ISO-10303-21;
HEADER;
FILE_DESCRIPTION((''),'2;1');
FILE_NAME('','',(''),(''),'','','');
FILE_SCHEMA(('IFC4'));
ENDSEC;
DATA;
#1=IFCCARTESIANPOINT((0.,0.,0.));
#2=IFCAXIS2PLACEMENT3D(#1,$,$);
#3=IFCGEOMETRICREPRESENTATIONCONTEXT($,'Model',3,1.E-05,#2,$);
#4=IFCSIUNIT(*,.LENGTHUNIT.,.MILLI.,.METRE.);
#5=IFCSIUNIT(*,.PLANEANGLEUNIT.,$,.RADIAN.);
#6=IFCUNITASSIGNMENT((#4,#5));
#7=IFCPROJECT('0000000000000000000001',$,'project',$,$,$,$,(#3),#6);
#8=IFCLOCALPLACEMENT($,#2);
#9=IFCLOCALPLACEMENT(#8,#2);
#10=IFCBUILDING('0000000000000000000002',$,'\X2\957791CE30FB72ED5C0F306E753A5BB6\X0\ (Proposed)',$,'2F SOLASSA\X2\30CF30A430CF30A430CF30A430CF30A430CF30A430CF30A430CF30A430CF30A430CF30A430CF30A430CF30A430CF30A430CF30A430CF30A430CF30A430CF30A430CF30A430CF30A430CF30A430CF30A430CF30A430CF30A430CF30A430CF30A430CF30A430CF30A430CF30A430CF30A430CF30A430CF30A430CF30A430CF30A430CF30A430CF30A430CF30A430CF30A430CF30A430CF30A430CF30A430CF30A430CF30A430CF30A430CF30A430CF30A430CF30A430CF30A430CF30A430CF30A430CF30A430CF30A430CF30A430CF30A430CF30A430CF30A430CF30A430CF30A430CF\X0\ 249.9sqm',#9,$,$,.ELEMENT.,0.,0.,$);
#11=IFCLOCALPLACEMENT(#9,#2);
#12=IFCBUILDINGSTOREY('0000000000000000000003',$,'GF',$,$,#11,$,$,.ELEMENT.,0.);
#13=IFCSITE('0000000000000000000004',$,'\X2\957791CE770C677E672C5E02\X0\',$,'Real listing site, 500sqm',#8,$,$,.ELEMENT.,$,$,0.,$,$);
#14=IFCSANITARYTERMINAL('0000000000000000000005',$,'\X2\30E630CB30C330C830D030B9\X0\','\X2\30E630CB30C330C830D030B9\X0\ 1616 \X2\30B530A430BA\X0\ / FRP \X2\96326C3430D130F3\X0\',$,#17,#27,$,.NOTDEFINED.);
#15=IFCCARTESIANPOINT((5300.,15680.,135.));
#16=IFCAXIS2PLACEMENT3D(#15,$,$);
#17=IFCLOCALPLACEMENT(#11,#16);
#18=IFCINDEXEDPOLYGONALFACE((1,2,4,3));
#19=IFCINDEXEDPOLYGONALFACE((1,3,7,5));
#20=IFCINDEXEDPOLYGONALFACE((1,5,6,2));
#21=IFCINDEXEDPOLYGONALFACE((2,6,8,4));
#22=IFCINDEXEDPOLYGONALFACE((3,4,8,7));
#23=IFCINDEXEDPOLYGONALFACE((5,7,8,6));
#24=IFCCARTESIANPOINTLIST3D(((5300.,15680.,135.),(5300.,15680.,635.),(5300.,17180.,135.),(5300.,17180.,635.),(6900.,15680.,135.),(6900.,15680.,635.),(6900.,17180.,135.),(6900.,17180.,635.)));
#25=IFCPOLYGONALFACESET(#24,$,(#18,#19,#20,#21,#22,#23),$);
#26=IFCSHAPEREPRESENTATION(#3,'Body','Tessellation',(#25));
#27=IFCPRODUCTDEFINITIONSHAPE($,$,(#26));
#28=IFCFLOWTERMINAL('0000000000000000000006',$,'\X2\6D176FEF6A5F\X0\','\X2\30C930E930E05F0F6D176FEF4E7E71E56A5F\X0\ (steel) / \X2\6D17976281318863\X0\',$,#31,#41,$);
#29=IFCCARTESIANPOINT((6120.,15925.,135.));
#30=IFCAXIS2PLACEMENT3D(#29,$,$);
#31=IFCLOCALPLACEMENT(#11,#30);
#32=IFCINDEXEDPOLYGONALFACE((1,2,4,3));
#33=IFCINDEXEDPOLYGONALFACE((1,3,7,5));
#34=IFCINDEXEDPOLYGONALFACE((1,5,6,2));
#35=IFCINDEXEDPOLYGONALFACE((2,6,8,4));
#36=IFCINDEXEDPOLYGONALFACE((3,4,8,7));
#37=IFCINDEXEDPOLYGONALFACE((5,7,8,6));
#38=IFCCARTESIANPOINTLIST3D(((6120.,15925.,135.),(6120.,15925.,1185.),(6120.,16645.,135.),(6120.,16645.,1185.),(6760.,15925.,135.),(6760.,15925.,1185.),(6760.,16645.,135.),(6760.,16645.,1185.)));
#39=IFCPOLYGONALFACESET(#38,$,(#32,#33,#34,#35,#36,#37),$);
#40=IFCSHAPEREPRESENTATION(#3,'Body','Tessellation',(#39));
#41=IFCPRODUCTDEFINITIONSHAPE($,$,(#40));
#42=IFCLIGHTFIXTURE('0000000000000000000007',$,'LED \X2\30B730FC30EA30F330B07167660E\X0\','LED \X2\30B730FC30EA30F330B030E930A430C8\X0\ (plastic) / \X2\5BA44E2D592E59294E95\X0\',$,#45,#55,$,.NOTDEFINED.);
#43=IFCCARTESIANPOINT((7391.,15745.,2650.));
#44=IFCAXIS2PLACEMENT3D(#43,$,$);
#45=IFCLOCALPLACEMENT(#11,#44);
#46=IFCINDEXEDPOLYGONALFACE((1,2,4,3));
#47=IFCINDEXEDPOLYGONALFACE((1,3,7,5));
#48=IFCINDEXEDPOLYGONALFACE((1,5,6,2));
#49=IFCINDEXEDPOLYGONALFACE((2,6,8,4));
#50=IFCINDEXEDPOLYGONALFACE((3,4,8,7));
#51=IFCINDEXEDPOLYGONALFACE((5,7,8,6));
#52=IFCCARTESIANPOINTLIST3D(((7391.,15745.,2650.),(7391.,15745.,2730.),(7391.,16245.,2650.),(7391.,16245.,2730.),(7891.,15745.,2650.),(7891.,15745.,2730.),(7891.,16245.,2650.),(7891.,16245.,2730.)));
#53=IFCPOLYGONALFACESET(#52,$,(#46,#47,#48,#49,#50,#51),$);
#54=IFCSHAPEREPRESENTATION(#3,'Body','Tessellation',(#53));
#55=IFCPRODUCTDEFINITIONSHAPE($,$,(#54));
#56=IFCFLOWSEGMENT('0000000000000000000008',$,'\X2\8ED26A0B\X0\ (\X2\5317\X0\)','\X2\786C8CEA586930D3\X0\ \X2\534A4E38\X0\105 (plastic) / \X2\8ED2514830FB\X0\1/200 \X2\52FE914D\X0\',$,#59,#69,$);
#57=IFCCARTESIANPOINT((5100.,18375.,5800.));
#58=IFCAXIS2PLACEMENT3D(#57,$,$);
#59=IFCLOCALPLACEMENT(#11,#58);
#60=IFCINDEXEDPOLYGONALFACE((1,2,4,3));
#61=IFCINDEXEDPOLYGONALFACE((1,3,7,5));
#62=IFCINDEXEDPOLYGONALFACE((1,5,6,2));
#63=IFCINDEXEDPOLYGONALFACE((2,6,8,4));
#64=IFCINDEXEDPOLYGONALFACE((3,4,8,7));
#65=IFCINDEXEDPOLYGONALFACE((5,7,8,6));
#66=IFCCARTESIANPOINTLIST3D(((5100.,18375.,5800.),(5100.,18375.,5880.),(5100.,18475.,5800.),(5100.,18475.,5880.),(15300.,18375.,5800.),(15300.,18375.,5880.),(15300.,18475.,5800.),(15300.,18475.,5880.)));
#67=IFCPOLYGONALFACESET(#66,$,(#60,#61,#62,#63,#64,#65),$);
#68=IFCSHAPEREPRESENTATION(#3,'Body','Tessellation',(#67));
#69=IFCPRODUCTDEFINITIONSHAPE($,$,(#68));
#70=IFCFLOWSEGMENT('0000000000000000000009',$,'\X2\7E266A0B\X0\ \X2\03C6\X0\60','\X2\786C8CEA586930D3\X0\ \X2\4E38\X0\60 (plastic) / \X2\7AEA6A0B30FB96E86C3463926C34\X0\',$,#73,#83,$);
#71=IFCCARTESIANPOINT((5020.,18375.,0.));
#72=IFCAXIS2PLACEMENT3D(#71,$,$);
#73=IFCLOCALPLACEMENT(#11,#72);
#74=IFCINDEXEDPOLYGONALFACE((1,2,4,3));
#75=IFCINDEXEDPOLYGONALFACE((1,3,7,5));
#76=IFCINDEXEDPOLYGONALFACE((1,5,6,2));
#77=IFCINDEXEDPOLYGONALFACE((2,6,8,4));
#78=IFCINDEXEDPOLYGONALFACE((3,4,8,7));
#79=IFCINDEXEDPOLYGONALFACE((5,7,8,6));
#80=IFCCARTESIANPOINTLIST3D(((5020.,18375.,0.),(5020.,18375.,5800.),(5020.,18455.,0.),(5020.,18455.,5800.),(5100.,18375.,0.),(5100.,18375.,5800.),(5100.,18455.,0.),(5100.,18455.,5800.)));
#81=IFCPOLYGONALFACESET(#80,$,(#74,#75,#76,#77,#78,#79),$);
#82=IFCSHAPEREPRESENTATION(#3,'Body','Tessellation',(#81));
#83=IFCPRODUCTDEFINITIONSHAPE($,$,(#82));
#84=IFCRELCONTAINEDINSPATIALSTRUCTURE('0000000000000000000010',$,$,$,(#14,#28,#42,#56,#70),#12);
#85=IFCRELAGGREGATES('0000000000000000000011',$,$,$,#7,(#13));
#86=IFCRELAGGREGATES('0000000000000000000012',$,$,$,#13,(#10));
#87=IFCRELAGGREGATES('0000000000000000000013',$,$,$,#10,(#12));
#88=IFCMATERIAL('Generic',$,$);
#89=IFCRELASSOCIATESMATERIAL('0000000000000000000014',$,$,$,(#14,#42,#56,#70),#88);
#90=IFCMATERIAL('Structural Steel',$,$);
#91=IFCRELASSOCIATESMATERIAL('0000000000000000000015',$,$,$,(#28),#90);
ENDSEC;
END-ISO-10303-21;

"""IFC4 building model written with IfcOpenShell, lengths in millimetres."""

from ifc_helpers import new_model, si_unit, frame, frame_2d, origin, place, context, project, spatial, rectangle, extrude, material, element, save


model = new_model("IFC4")

# Units and contexts
model_context = context("Model", 3, precision=1e-05, world=origin())
ifc_project = project(units=[si_unit("LENGTHUNIT", "METRE", prefix="MILLI"), si_unit("PLANEANGLEUNIT", "RADIAN")], contexts=[model_context])

# Site, building, storey
site_placement = place(None, origin())
site = spatial("IfcSite", under=ifc_project, at=site_placement, Name="長野県松本市", ObjectType="Real listing site, 500sqm", CompositionType="ELEMENT", RefElevation=0.0)
building_placement = place(site_placement, origin())
building = spatial("IfcBuilding", under=site, at=building_placement, Name="長野・狭小の町家 (Proposed)", ObjectType="2F SOLASSAハイハイハイハイハイハイハイハイハイハイハイハイハイハイハイハイハイハイハイハイハイハイハイハイハイハイハイハイハイハイハイハイハイハイハイハイハイハイハイハイハイハイハイハイハイハイハイハイハイハイハイハイハイハイハイハイハ 249.9sqm", CompositionType="ELEMENT", ElevationOfRefHeight=0.0, ElevationOfTerrain=0.0)
storey_placement = place(building_placement, origin())
storey = spatial("IfcBuildingStorey", under=building, at=storey_placement, Name="GF", CompositionType="ELEMENT", Elevation=0.0)

# Sanitary terminal
ifc_material_1 = material(Name="Generic")
sanitary_terminal_placement = place(storey_placement, frame((5300.0, 15680.0, 135.0)))
element("IfcSanitaryTerminal", 1, at=sanitary_terminal_placement, inside=storey, material=ifc_material_1, Name="ユニットバス", Description="ユニットバス 1616 サイズ / FRP 防水パン", PredefinedType="NOTDEFINED", context=model_context, shape_type="SweptSolid", body=[
    extrude(rectangle(XDim=1600.0, YDim=1500.0, at=frame_2d((800.0, 750.0))), frame((5300.0, 15680.0, 135.0)), (0.0, 0.0, 1.0), 500.0),
])

# Flow terminal
ifc_material_2 = material(Name="Structural Steel")
flow_terminal_placement = place(storey_placement, frame((6120.0, 15925.0, 135.0)))
element("IfcFlowTerminal", 2, at=flow_terminal_placement, inside=storey, material=ifc_material_2, Name="洗濯機", Description="ドラム式洗濯乾燥機 (steel) / 洗面脱衣", context=model_context, shape_type="SweptSolid", body=[
    extrude(rectangle(XDim=640.0, YDim=720.0, at=frame_2d((320.0, 360.0))), frame((6120.0, 15925.0, 135.0)), (0.0, 0.0, 1.0), 1050.0),
])

# Light fixture
light_fixture_placement = place(storey_placement, frame((7391.0, 15745.0, 2650.0)))
element("IfcLightFixture", 3, at=light_fixture_placement, inside=storey, material=ifc_material_1, Name="LED シーリング照明", Description="LED シーリングライト (plastic) / 室中央天井", PredefinedType="NOTDEFINED", context=model_context, shape_type="SweptSolid", body=[
    extrude(rectangle(XDim=500.0, YDim=500.0, at=frame_2d((250.0, 250.0))), frame((7391.0, 15745.0, 2650.0)), (0.0, 0.0, 1.0), 80.0),
])

# Flow segments
flow_segment_1_placement = place(storey_placement, frame((5100.0, 18375.0, 5800.0)))
element("IfcFlowSegment", 4, at=flow_segment_1_placement, inside=storey, material=ifc_material_1, Name="軒樋 (北)", Description="硬質塩ビ 半丸105 (plastic) / 軒先・1/200 勾配", context=model_context, shape_type="SweptSolid", body=[
    extrude(rectangle(XDim=10200.0, YDim=100.0, at=frame_2d((5100.0, 50.0))), frame((5100.0, 18375.0, 5800.0)), (0.0, 0.0, 1.0), 80.0),
])
flow_segment_2_placement = place(storey_placement, frame((5020.0, 18375.0, 0.0)))
element("IfcFlowSegment", 5, at=flow_segment_2_placement, inside=storey, material=ifc_material_1, Name="縦樋 φ60", Description="硬質塩ビ 丸60 (plastic) / 竪樋・雨水排水", context=model_context, shape_type="SweptSolid", body=[
    extrude(rectangle(XDim=80.0, YDim=80.0, at=frame_2d((40.0, 40.0))), frame((5020.0, 18375.0, 0.0)), (0.0, 0.0, 1.0), 5800.0),
])

save(model, "model.ifc")
